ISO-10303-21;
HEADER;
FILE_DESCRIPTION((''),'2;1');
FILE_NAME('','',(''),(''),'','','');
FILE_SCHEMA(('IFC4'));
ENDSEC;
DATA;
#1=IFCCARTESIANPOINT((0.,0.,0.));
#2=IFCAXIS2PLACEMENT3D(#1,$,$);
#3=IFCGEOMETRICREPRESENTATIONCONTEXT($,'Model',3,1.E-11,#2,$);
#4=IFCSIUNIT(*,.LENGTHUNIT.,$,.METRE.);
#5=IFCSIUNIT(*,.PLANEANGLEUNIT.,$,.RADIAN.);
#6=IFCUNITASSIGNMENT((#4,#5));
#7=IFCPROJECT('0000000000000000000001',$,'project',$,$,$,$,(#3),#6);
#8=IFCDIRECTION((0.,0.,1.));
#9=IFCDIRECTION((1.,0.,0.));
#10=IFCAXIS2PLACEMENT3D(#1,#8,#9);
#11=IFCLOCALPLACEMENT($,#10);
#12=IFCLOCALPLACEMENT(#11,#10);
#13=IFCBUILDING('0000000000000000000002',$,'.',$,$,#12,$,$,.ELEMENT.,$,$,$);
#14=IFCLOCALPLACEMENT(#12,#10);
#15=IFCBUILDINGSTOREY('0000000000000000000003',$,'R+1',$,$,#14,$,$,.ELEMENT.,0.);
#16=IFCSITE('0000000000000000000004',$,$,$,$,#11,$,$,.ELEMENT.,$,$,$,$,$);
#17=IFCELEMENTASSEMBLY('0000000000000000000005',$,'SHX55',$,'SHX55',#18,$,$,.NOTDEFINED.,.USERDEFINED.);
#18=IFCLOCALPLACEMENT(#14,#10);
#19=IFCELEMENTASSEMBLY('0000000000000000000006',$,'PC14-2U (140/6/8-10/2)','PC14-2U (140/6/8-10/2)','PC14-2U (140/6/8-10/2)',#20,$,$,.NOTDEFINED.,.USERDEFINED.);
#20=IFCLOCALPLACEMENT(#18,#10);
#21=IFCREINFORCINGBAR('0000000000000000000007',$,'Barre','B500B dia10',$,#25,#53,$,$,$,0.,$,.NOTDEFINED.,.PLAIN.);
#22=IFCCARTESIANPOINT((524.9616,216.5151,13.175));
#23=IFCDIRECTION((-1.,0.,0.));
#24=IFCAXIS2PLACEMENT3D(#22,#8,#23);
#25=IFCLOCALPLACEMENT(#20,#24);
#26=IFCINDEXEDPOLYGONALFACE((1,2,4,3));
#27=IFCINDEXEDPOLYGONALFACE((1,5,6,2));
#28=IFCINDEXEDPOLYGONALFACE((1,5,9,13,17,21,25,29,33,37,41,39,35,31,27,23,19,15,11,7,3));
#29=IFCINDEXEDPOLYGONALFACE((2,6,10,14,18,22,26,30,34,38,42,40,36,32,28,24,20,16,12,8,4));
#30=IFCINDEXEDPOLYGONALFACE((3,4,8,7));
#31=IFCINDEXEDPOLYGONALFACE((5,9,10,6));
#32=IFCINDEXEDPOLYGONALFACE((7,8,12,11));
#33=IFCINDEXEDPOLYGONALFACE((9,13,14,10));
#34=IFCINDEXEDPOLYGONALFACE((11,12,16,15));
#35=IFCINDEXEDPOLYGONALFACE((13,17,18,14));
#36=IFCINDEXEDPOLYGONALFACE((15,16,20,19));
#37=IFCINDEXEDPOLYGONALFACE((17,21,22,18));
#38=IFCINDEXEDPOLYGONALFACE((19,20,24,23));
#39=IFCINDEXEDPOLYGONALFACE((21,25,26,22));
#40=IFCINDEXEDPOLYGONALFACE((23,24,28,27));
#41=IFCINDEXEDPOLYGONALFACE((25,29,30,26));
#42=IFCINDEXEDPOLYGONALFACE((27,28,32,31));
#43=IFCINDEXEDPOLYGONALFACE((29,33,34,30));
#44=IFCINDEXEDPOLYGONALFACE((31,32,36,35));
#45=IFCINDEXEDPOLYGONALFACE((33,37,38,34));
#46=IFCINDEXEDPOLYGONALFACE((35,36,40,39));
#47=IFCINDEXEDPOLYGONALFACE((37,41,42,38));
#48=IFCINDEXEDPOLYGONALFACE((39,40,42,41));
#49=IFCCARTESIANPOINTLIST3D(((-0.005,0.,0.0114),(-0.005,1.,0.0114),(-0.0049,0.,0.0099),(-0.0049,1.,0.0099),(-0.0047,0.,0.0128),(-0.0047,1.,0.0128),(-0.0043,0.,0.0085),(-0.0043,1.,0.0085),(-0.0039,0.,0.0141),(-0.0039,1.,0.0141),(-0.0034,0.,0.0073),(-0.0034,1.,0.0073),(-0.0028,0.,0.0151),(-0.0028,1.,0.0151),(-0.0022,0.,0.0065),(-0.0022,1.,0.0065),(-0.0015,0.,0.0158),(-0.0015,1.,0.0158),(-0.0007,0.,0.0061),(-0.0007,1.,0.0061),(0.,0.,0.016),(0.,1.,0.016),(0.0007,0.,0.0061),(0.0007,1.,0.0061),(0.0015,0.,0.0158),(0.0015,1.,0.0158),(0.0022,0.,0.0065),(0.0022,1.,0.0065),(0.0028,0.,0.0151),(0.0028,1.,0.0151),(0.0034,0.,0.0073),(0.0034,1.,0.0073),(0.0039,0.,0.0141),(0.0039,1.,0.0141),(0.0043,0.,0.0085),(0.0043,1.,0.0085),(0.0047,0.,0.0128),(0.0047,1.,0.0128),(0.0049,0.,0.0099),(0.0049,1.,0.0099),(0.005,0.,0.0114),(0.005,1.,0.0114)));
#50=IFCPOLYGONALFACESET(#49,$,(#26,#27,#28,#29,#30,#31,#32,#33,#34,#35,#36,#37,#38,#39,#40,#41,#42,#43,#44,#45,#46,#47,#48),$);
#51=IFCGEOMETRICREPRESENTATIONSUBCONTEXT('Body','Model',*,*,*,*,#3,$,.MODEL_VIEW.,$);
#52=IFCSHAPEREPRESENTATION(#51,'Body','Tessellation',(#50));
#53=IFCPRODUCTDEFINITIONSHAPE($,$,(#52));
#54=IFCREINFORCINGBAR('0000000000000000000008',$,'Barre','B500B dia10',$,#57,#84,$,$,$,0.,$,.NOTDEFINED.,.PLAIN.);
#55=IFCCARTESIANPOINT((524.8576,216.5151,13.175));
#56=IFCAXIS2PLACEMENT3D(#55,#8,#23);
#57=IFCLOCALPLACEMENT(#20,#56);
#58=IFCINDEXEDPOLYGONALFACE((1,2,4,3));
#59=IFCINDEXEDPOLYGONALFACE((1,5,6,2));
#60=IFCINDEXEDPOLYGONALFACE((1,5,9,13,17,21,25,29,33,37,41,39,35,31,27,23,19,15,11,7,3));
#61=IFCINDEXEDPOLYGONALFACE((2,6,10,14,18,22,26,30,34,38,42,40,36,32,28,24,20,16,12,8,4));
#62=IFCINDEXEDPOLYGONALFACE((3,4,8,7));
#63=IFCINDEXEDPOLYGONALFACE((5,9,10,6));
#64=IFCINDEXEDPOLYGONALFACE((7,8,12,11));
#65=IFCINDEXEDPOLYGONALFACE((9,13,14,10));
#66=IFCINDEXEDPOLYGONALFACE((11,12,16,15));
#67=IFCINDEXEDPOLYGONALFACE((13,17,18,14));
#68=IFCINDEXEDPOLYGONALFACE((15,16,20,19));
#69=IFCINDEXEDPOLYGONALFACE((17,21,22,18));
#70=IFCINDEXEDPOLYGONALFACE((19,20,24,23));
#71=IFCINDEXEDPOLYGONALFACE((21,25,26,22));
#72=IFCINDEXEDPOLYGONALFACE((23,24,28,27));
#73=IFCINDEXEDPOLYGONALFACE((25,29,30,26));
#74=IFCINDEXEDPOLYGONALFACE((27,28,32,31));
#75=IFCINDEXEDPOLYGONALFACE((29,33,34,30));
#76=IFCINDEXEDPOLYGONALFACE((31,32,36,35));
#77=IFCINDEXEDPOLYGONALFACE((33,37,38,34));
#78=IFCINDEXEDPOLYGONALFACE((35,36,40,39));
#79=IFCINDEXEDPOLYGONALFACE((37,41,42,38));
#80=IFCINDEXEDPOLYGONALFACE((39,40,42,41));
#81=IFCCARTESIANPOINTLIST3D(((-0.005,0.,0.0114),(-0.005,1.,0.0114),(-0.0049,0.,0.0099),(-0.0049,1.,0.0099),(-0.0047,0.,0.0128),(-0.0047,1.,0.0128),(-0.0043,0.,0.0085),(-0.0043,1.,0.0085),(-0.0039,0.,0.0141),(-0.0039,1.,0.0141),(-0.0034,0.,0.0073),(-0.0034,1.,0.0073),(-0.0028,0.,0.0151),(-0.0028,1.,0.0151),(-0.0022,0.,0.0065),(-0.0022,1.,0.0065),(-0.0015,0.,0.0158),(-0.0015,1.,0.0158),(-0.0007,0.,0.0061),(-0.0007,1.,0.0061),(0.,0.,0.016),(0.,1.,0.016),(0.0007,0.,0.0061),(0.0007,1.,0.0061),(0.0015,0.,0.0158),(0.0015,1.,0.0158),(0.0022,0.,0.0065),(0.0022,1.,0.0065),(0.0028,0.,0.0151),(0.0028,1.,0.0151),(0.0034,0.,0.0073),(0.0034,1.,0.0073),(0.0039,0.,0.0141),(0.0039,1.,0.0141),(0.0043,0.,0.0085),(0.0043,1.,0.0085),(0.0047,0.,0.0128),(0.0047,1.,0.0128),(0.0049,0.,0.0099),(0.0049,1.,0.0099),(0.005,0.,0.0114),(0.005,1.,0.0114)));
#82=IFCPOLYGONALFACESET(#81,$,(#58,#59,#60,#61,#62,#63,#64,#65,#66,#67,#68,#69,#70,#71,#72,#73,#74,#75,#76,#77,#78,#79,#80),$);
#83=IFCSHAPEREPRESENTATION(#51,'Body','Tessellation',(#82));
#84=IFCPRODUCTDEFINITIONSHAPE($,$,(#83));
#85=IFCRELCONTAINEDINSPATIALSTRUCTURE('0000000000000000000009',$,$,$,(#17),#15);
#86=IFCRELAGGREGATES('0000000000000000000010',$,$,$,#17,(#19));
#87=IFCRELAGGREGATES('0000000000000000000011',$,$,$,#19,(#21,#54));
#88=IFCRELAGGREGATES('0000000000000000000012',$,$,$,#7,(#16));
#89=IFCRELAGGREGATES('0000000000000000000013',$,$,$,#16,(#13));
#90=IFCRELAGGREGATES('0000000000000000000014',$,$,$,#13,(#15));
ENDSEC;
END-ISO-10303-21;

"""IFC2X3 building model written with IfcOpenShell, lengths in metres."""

from ifc_helpers import new_model, entity, si_unit, frame, origin, origin_with_axes, place, context, subcontext, project, spatial, source, transform, mapped, element, aggregate, save


model = new_model("IFC2X3")

# Units and contexts
model_context = context("Model", 3, precision=1e-11, world=origin())
body_context = subcontext(model_context, "Body", "Model", "MODEL_VIEW")
ifc_project = project(units=[si_unit("LENGTHUNIT", "METRE"), si_unit("PLANEANGLEUNIT", "RADIAN")], contexts=[model_context])

# Site, building, storey
site_placement = place(None, origin_with_axes())
site = spatial("IfcSite", under=ifc_project, at=site_placement, CompositionType="ELEMENT")
building_placement = place(site_placement, origin_with_axes())
building = spatial("IfcBuilding", under=site, at=building_placement, Name=".", CompositionType="ELEMENT")
storey_placement = place(building_placement, origin_with_axes())
storey = spatial("IfcBuildingStorey", under=building, at=storey_placement, Name="R+1", CompositionType="ELEMENT", Elevation=0.0)

# Element assemblies, reinforcing bars
assembly_1_placement = place(storey_placement, origin_with_axes())
assembly_1 = element("IfcElementAssembly", 1, at=assembly_1_placement, inside=storey, Name="SHX55", ObjectType="SHX55", AssemblyPlace="NOTDEFINED", PredefinedType="USERDEFINED")
assembly_2_placement = place(assembly_1_placement, origin_with_axes())
assembly_2 = element("IfcElementAssembly", 2, at=assembly_2_placement, Name="PC14-2U (140/6/8-10/2)", Description="PC14-2U (140/6/8-10/2)", ObjectType="PC14-2U (140/6/8-10/2)", AssemblyPlace="NOTDEFINED", PredefinedType="USERDEFINED")
aggregate(assembly_1, [assembly_2])
shared_shape_1 = source(origin_with_axes(), body_context, "Body", "AdvancedSweptSolid", [
    entity("IfcSweptDiskSolid", entity("IfcPolyline", [entity("IfcCartesianPoint", [0.0, 0.0, 0.011]), entity("IfcCartesianPoint", [0.0, 1.0, 0.011])]), 0.005, None, 0.0, 1.0),
])
reinforcing_bar_1_placement = place(assembly_2_placement, frame((524.9616, 216.5151, 13.175), z_axis=(0.0, 0.0, 1.0), x_axis=(-1.0, 0.0, 0.0)))
reinforcing_bar_1 = element("IfcReinforcingBar", 3, at=reinforcing_bar_1_placement, Name="Barre", Description="B500B dia10", BarRole="NOTDEFINED", BarSurface="PLAIN", CrossSectionArea=0.0, context=body_context, shape_type="MappedRepresentation", body=[
    mapped(shared_shape_1, transform((0.0, 0.0, 0.0), scale=1.0)),
])
reinforcing_bar_2_placement = place(assembly_2_placement, frame((524.8576, 216.5151, 13.175), z_axis=(0.0, 0.0, 1.0), x_axis=(-1.0, 0.0, 0.0)))
reinforcing_bar_2 = element("IfcReinforcingBar", 4, at=reinforcing_bar_2_placement, Name="Barre", Description="B500B dia10", BarRole="NOTDEFINED", BarSurface="PLAIN", CrossSectionArea=0.0, context=body_context, shape_type="MappedRepresentation", body=[
    mapped(shared_shape_1, transform((0.0, 0.0, 0.0), scale=1.0)),
])
aggregate(assembly_2, [reinforcing_bar_1, reinforcing_bar_2])

save(model, "model.ifc")
